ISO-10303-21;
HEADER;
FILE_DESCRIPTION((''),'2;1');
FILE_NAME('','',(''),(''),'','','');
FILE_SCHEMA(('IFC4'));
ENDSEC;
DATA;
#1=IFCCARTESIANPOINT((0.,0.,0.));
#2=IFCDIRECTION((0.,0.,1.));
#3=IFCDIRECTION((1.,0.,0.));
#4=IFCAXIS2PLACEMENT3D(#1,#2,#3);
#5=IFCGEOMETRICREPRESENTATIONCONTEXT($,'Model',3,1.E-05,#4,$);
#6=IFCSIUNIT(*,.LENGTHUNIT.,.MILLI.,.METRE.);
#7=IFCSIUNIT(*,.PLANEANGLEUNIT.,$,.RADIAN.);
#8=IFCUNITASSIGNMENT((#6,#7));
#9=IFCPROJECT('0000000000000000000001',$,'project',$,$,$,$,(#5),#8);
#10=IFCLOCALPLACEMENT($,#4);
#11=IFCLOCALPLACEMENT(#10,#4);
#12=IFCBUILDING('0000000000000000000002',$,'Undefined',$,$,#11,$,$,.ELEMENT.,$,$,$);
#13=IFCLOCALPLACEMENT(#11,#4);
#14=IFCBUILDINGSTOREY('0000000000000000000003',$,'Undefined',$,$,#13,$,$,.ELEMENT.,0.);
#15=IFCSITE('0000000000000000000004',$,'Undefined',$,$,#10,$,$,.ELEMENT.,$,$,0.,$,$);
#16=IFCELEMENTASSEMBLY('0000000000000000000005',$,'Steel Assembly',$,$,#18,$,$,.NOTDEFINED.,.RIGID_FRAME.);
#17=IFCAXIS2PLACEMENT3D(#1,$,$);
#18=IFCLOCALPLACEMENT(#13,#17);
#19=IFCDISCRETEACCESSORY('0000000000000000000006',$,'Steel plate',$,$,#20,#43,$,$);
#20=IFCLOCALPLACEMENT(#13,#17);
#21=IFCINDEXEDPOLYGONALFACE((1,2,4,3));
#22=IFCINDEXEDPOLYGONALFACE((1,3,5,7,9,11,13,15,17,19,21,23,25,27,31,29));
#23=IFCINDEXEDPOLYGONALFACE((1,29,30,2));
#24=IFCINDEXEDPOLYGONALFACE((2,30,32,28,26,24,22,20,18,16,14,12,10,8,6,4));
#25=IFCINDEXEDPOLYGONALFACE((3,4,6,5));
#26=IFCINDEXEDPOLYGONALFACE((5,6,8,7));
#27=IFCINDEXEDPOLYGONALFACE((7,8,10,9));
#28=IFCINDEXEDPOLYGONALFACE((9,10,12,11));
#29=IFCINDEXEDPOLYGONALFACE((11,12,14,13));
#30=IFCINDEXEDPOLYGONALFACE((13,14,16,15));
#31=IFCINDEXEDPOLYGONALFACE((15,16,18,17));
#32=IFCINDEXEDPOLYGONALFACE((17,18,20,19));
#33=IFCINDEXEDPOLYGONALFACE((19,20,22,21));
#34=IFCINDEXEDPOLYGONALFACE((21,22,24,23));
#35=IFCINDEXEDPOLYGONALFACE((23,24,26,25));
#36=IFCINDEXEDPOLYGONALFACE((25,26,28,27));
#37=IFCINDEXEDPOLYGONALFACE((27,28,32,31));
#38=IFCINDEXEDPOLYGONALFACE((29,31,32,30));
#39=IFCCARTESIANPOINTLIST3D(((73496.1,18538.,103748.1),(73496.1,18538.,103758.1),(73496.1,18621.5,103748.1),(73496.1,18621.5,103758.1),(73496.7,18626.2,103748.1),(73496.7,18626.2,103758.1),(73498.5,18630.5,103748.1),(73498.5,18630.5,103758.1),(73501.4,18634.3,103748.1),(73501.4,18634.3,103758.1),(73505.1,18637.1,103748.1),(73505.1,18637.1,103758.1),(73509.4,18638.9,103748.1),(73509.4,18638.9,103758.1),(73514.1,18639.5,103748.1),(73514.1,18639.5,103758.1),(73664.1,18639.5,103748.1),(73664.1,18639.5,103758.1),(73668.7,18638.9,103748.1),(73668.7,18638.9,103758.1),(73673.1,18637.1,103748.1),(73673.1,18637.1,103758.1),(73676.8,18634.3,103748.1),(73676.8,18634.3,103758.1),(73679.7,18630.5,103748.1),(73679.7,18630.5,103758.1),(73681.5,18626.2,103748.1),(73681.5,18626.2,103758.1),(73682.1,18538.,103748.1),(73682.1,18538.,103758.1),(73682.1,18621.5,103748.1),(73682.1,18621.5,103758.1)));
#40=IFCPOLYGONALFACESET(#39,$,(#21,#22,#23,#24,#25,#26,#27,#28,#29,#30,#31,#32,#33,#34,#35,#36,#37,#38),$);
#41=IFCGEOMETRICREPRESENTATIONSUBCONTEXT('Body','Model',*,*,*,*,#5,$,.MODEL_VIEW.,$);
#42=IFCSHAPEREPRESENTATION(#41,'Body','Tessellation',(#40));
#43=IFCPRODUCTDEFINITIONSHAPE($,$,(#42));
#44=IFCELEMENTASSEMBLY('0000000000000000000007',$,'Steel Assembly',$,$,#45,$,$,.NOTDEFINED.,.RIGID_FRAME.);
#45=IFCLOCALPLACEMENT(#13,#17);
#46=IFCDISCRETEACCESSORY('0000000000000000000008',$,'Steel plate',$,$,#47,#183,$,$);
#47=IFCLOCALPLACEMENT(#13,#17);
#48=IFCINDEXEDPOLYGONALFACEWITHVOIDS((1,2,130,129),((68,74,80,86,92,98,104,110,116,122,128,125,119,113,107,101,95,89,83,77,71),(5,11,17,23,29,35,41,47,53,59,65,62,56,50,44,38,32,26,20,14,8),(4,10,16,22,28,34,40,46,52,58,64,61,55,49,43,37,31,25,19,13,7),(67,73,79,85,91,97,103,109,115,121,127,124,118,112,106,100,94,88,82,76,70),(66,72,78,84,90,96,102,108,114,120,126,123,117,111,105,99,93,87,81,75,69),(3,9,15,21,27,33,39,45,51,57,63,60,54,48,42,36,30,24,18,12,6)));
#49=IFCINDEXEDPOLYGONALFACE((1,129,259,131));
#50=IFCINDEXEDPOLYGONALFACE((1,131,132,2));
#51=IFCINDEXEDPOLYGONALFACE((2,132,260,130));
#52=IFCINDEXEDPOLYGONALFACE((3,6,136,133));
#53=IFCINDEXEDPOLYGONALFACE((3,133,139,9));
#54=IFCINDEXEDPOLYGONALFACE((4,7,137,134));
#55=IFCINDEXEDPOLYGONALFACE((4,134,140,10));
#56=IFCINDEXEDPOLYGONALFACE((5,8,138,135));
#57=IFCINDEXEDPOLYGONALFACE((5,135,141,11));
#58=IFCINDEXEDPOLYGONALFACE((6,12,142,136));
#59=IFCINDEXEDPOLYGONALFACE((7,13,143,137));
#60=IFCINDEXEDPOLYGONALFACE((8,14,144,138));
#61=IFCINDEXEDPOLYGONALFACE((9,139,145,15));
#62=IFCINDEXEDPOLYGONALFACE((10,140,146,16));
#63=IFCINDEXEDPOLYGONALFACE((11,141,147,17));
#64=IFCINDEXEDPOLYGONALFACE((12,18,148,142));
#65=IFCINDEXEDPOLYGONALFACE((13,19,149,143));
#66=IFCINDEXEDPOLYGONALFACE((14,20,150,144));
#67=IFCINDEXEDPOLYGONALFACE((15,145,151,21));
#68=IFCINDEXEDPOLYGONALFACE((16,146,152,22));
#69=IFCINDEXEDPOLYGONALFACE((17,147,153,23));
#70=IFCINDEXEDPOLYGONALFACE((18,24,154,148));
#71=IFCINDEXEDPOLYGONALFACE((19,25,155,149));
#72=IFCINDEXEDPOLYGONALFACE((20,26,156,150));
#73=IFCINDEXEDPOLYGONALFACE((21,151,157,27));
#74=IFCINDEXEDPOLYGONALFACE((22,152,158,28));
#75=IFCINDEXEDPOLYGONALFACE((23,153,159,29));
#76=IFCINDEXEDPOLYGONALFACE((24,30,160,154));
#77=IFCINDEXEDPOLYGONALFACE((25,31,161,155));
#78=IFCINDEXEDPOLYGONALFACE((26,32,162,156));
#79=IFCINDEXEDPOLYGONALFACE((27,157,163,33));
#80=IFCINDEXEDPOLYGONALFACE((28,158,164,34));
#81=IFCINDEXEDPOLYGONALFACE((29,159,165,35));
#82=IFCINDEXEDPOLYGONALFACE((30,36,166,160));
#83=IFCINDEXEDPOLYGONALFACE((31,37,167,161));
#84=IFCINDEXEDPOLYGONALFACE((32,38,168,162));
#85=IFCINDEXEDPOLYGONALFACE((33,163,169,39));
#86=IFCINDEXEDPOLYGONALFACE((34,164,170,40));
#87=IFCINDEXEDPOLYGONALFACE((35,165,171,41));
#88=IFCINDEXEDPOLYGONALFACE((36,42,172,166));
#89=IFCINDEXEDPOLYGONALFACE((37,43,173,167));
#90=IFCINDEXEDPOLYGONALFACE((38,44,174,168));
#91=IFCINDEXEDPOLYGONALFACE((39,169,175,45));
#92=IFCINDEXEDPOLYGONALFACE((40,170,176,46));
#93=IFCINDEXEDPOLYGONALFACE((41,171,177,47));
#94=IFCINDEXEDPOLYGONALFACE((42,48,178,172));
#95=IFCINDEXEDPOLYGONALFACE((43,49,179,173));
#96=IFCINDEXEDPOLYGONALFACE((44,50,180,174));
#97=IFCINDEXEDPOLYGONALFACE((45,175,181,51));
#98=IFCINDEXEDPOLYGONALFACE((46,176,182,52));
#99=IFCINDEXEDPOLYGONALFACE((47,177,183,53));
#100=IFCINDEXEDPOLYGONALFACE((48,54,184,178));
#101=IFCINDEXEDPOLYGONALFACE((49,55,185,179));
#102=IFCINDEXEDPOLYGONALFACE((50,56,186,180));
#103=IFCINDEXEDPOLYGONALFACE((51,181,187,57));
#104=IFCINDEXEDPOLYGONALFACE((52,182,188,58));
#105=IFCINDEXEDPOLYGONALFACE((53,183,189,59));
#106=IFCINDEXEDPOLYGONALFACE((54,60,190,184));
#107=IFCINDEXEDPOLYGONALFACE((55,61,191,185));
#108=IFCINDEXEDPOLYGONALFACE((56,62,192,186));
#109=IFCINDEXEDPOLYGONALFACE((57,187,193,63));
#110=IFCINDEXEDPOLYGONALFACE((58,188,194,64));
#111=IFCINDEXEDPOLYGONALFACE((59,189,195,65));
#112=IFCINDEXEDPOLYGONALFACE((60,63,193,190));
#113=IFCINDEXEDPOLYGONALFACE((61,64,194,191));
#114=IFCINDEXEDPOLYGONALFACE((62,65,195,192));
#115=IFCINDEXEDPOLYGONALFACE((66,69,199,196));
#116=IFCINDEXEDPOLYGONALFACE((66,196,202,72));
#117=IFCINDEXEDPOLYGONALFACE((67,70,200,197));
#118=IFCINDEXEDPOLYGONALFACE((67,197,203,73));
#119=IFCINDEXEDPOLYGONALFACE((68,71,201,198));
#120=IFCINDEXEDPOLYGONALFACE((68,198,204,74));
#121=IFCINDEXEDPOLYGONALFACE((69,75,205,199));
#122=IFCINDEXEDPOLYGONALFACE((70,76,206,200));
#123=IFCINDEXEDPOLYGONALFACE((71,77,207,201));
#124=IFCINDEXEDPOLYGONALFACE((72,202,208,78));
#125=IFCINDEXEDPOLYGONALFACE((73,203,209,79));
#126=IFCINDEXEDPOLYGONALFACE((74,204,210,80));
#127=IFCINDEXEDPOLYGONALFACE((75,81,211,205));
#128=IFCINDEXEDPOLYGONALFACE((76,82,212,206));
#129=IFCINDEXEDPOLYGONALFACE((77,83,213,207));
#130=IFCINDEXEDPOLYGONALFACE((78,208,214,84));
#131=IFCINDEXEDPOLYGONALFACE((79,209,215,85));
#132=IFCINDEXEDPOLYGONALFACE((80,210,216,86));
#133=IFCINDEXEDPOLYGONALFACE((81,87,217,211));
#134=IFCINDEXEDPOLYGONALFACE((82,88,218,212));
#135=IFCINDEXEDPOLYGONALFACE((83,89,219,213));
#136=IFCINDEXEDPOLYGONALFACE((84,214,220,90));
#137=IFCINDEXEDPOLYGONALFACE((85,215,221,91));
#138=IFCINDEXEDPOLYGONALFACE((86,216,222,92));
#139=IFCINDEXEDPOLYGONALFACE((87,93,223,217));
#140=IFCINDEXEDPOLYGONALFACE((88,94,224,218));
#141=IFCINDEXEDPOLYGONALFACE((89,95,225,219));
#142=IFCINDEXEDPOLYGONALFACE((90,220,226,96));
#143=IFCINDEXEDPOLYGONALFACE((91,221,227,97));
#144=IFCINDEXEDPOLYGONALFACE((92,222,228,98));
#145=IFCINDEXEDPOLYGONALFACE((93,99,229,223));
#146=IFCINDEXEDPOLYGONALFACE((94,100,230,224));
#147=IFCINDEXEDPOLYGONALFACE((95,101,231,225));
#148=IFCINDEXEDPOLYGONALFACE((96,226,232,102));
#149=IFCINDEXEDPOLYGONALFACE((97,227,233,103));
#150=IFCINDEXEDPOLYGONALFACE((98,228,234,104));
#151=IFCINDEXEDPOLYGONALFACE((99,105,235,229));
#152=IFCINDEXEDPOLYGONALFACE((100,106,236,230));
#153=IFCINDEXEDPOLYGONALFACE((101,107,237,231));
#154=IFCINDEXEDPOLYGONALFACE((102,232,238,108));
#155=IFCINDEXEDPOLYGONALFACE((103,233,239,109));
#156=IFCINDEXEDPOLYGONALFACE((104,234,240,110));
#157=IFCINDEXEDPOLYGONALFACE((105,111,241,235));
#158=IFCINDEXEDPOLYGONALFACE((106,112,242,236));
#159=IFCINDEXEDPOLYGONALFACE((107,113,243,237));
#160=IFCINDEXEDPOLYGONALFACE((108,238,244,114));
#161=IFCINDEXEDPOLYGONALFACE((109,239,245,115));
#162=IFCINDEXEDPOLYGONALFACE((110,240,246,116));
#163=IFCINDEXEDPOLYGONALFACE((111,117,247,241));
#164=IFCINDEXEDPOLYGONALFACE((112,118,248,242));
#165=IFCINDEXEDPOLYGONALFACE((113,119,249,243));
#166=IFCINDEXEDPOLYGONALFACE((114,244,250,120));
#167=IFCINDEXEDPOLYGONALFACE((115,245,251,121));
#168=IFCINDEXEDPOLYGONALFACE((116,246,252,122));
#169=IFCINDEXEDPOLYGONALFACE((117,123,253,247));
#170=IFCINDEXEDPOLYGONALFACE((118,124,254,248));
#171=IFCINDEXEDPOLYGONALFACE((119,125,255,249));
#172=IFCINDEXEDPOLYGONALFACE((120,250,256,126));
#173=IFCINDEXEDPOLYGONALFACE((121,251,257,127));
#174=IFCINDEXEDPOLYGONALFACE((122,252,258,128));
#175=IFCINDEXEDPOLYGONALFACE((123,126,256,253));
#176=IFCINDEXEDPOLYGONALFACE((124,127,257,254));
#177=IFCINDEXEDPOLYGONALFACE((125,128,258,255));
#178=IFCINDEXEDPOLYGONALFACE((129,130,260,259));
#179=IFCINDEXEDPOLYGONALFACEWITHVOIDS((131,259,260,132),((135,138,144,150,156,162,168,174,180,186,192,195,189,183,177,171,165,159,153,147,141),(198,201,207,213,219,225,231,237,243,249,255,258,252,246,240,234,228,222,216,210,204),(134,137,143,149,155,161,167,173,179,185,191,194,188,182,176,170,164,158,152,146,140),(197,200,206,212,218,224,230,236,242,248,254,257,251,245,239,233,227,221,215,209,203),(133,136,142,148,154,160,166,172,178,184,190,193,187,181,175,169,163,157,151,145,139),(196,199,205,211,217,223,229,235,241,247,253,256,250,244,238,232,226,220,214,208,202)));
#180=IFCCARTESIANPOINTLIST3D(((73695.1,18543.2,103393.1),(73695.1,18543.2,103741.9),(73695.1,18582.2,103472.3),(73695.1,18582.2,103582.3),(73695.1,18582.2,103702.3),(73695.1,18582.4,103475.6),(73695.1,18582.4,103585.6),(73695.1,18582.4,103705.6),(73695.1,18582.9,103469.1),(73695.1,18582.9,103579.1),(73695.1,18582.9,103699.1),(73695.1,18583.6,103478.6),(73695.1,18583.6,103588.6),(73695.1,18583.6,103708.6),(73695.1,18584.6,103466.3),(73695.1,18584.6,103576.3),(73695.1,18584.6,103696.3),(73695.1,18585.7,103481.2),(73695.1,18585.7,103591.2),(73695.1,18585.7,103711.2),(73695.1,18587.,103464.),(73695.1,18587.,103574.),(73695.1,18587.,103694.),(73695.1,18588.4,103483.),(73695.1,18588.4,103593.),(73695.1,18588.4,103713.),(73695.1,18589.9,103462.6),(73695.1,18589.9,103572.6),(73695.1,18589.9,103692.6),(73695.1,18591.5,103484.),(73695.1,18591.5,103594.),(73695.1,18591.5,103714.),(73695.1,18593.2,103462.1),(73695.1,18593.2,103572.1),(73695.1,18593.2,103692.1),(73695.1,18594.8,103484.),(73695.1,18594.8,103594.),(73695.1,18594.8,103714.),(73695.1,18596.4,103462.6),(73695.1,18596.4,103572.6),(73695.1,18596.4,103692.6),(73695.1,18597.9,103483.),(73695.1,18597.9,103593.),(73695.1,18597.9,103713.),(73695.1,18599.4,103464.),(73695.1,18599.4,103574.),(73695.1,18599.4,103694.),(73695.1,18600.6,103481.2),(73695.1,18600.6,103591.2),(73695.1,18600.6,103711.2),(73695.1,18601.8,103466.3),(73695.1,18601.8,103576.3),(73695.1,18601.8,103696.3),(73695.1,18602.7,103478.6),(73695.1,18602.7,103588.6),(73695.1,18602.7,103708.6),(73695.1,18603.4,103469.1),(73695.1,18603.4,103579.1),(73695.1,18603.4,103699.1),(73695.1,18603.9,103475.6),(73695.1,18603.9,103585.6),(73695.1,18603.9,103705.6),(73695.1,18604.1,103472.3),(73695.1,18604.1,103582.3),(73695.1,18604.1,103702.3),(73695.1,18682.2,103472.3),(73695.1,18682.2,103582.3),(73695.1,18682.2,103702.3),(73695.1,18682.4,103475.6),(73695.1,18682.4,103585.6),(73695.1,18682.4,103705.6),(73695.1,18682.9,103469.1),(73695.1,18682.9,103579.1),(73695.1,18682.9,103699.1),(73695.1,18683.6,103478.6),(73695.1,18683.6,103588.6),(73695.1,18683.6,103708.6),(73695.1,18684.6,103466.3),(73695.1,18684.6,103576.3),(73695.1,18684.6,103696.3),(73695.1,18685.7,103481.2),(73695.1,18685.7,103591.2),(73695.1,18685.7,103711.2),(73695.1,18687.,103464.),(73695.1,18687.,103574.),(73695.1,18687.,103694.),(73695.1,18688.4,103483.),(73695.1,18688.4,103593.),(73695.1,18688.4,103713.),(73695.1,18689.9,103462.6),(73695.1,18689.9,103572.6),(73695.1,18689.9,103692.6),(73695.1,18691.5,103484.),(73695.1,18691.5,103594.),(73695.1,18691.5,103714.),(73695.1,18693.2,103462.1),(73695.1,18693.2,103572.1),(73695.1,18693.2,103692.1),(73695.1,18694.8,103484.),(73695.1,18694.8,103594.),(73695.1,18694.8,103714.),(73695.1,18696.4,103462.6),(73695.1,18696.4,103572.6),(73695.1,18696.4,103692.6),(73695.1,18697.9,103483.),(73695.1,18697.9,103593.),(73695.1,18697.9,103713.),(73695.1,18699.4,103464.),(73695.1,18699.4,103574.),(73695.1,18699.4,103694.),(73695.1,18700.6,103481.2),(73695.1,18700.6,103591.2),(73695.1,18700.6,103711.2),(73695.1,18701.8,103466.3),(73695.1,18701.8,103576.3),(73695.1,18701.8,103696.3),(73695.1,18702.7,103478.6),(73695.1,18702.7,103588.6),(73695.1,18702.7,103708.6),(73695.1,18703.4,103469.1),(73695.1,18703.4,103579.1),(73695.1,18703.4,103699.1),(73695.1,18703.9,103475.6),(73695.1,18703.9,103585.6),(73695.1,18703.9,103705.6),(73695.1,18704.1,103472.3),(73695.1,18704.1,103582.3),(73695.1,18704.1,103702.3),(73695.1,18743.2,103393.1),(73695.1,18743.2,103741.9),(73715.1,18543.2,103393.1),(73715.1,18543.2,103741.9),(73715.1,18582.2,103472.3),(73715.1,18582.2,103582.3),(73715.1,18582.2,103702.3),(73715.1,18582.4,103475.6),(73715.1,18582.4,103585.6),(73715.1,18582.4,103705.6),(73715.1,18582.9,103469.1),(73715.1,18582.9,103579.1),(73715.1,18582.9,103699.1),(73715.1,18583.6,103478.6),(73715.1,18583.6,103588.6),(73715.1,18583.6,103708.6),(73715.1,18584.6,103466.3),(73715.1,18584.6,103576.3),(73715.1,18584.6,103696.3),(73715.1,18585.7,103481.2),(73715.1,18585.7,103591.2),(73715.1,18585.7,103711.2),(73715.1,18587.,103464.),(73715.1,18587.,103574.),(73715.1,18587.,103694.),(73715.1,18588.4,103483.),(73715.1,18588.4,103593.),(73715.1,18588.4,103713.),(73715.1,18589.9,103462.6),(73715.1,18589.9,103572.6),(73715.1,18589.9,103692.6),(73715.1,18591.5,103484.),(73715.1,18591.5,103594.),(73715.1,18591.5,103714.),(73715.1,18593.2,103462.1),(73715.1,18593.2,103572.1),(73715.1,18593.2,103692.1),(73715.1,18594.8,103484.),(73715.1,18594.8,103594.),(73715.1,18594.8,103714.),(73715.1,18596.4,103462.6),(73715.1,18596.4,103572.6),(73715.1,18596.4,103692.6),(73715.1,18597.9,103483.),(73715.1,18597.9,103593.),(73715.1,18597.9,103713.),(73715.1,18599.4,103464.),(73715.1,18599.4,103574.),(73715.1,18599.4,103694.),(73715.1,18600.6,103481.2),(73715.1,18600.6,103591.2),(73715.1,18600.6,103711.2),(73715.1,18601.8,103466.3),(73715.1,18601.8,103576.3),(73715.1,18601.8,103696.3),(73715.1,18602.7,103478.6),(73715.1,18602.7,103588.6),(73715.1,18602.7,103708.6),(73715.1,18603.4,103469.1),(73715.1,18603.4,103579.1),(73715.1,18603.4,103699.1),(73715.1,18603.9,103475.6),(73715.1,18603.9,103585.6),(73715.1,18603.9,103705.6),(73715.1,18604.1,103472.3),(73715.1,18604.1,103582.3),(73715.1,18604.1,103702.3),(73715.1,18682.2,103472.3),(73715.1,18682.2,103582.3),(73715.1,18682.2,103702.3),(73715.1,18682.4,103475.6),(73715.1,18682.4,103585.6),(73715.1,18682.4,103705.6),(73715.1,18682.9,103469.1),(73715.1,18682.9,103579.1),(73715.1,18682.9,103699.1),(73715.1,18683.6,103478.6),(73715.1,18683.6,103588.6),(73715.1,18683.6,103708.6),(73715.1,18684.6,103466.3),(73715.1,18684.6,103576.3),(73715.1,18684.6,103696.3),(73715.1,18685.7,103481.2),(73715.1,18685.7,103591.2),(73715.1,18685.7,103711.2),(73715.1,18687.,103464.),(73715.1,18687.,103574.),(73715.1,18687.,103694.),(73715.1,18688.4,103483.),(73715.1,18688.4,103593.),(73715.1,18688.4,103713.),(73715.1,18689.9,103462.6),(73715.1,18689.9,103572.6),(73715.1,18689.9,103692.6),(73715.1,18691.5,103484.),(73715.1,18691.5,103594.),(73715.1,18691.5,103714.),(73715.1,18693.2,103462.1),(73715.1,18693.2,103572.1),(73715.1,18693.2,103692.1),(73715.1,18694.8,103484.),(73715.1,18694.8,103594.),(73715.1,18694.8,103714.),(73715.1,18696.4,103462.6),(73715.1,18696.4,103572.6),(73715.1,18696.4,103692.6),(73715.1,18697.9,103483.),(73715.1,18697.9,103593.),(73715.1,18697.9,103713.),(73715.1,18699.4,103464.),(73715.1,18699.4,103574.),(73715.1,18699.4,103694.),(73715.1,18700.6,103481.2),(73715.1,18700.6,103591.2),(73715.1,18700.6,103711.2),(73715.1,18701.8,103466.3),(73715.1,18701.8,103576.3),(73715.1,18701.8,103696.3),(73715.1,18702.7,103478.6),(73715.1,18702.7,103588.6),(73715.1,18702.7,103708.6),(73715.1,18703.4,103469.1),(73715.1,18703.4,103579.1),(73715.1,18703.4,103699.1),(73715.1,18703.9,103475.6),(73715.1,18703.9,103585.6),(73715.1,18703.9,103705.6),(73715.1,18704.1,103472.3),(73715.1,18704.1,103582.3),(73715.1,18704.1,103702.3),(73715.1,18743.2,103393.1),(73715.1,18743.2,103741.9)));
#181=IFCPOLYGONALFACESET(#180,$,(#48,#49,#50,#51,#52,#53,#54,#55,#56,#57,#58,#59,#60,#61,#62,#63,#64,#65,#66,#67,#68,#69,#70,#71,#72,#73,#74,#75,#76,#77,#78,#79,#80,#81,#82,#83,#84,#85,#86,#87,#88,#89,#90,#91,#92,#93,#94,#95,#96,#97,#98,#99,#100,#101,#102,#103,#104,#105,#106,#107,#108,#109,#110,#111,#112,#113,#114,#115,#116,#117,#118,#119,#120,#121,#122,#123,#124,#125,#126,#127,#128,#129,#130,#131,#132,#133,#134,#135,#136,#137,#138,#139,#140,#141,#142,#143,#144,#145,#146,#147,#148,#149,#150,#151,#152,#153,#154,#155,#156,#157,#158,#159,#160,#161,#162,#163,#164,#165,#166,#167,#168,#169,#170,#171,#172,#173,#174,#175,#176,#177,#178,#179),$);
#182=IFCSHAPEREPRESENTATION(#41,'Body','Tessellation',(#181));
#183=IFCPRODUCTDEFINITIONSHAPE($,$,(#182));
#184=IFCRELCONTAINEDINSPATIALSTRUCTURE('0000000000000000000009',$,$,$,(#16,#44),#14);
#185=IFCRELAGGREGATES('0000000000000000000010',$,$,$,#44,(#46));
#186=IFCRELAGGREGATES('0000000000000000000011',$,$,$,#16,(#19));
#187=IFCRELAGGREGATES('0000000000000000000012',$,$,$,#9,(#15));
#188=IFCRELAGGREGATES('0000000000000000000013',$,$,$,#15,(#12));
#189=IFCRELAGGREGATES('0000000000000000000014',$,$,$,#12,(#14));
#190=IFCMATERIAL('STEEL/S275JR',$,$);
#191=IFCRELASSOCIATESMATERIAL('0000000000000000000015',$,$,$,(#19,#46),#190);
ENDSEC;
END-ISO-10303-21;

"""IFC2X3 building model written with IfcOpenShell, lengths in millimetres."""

from ifc_helpers import new_model, si_unit, frame, frame_2d, origin_with_axes, origin_2d_with_axis, place, context, subcontext, project, spatial, polyline, circle_curve, parameter, trimmed, segment, composite_curve, circle, outline, extrude, source, transform, mapped, material, element, aggregate, save


model = new_model("IFC2X3")

# Units and contexts
model_context = context("Model", 3, precision=1e-05, world=origin_with_axes())
body_context = subcontext(model_context, "Body", "Model", "MODEL_VIEW")
ifc_project = project(units=[si_unit("LENGTHUNIT", "METRE", prefix="MILLI"), si_unit("PLANEANGLEUNIT", "RADIAN")], contexts=[model_context])

# Site, building, storey
site_placement = place(None, origin_with_axes())
site = spatial("IfcSite", under=ifc_project, at=site_placement, Name="Undefined", CompositionType="ELEMENT", RefElevation=0.0)
building_placement = place(site_placement, origin_with_axes())
building = spatial("IfcBuilding", under=site, at=building_placement, Name="Undefined", CompositionType="ELEMENT")
storey_placement = place(building_placement, origin_with_axes())
storey = spatial("IfcBuildingStorey", under=building, at=storey_placement, Name="Undefined", CompositionType="ELEMENT", Elevation=0.0)

# Element assembly
assembly_1_placement = place(storey_placement, origin_with_axes())
assembly_1 = element("IfcElementAssembly", 1, at=assembly_1_placement, inside=storey, Name="Steel Assembly", AssemblyPlace="NOTDEFINED", PredefinedType="RIGID_FRAME")

# Shared definitions
ifc_material_1 = material(Name="STEEL/S275JR")

# Discrete accessory
discrete_accessory_1_placement = place(assembly_1_placement, frame((73496.1, 18538.0, 103753.1), z_axis=(0.0, 0.0, 1.0), x_axis=(1.0, 0.0, 0.0)))
discrete_accessory_1 = element("IfcDiscreteAccessory", 2, at=discrete_accessory_1_placement, material=ifc_material_1, Name="Steel plate", context=body_context, shape_type="SweptSolid", body=[
    extrude(outline(composite_curve([segment(polyline([(0.0, 0.0), (186.0, 0.0), (186.0, 83.5)]), True, "CONTINUOUS"), segment(trimmed(circle_curve(frame_2d((168.0, 83.5), x_axis=(1.0, 0.0)), 18.0), [parameter(0.0)], [parameter(1.570796)], True, "PARAMETER"), True, "CONTINUOUS"), segment(polyline([(168.0, 101.5), (18.0, 101.5)]), True, "CONTINUOUS"), segment(trimmed(circle_curve(frame_2d((18.0, 83.5), x_axis=(0.0, 1.0)), 18.0), [parameter(0.0)], [parameter(1.570796)], True, "PARAMETER"), True, "CONTINUOUS"), segment(polyline([(0.0, 83.5), (0.0, 0.0)]), True, "DISCONTINUOUS")], self_intersect=False)), frame((0.0, 0.0, -5.0), z_axis=(0.0, 0.0, 1.0), x_axis=(1.0, 0.0, 0.0)), (0.0, 0.0, 1.0), 10.0),
])

# Element assembly, discrete accessory, opening
assembly_2_placement = place(storey_placement, origin_with_axes())
assembly_2 = element("IfcElementAssembly", 3, at=assembly_2_placement, inside=storey, Name="Steel Assembly", AssemblyPlace="NOTDEFINED", PredefinedType="RIGID_FRAME")
discrete_accessory_2_placement = place(assembly_2_placement, frame((73705.1, 18543.2, 103741.9), z_axis=(-1.0, 0.0, 0.0), x_axis=(0.0, 1.0, 0.0)))
discrete_accessory_2 = element("IfcDiscreteAccessory", 4, at=discrete_accessory_2_placement, material=ifc_material_1, Name="Steel plate", context=body_context, shape_type="SweptSolid", body=[
    extrude(outline(polyline([(0.0, 0.0), (200.0, 0.0), (200.0, 348.8), (0.0, 348.8), (0.0, 0.0)])), frame((0.0, 0.0, -10.0), z_axis=(0.0, 0.0, 1.0), x_axis=(1.0, 0.0, 0.0)), (0.0, 0.0, 1.0), 20.0),
])
shared_shape_1 = source(origin_with_axes(), body_context, "Body", "SweptSolid", [
    extrude(circle(Radius=11.0, at=origin_2d_with_axis()), frame((0.0, -20.1, 0.0), z_axis=(0.0, 1.0, 0.0), x_axis=(1.0, 0.0, 0.0)), (0.0, 0.0, 1.0), 40.3),
])
opening_1_placement = place(assembly_2_placement, frame((73695.1, 18643.2, 103703.1), z_axis=(0.0, 1.0, 0.0), x_axis=(0.0, 0.0, -1.0)))
element("IfcOpeningElement", 5, at=opening_1_placement, cuts=discrete_accessory_2, ObjectType="Opening", context=body_context, shape_type="MappedRepresentation", body=[
    mapped(shared_shape_1, transform((0.0, 0.0, -50.0))),
    mapped(shared_shape_1, transform((120.0, 0.0, -50.0))),
    mapped(shared_shape_1, transform((230.0, 0.0, -50.0))),
    mapped(shared_shape_1, transform((0.0, 0.0, 50.0))),
    mapped(shared_shape_1, transform((120.0, 0.0, 50.0))),
    mapped(shared_shape_1, transform((230.0, 0.0, 50.0))),
])
aggregate(assembly_2, [discrete_accessory_2])

aggregate(assembly_1, [discrete_accessory_1])

save(model, "model.ifc")
